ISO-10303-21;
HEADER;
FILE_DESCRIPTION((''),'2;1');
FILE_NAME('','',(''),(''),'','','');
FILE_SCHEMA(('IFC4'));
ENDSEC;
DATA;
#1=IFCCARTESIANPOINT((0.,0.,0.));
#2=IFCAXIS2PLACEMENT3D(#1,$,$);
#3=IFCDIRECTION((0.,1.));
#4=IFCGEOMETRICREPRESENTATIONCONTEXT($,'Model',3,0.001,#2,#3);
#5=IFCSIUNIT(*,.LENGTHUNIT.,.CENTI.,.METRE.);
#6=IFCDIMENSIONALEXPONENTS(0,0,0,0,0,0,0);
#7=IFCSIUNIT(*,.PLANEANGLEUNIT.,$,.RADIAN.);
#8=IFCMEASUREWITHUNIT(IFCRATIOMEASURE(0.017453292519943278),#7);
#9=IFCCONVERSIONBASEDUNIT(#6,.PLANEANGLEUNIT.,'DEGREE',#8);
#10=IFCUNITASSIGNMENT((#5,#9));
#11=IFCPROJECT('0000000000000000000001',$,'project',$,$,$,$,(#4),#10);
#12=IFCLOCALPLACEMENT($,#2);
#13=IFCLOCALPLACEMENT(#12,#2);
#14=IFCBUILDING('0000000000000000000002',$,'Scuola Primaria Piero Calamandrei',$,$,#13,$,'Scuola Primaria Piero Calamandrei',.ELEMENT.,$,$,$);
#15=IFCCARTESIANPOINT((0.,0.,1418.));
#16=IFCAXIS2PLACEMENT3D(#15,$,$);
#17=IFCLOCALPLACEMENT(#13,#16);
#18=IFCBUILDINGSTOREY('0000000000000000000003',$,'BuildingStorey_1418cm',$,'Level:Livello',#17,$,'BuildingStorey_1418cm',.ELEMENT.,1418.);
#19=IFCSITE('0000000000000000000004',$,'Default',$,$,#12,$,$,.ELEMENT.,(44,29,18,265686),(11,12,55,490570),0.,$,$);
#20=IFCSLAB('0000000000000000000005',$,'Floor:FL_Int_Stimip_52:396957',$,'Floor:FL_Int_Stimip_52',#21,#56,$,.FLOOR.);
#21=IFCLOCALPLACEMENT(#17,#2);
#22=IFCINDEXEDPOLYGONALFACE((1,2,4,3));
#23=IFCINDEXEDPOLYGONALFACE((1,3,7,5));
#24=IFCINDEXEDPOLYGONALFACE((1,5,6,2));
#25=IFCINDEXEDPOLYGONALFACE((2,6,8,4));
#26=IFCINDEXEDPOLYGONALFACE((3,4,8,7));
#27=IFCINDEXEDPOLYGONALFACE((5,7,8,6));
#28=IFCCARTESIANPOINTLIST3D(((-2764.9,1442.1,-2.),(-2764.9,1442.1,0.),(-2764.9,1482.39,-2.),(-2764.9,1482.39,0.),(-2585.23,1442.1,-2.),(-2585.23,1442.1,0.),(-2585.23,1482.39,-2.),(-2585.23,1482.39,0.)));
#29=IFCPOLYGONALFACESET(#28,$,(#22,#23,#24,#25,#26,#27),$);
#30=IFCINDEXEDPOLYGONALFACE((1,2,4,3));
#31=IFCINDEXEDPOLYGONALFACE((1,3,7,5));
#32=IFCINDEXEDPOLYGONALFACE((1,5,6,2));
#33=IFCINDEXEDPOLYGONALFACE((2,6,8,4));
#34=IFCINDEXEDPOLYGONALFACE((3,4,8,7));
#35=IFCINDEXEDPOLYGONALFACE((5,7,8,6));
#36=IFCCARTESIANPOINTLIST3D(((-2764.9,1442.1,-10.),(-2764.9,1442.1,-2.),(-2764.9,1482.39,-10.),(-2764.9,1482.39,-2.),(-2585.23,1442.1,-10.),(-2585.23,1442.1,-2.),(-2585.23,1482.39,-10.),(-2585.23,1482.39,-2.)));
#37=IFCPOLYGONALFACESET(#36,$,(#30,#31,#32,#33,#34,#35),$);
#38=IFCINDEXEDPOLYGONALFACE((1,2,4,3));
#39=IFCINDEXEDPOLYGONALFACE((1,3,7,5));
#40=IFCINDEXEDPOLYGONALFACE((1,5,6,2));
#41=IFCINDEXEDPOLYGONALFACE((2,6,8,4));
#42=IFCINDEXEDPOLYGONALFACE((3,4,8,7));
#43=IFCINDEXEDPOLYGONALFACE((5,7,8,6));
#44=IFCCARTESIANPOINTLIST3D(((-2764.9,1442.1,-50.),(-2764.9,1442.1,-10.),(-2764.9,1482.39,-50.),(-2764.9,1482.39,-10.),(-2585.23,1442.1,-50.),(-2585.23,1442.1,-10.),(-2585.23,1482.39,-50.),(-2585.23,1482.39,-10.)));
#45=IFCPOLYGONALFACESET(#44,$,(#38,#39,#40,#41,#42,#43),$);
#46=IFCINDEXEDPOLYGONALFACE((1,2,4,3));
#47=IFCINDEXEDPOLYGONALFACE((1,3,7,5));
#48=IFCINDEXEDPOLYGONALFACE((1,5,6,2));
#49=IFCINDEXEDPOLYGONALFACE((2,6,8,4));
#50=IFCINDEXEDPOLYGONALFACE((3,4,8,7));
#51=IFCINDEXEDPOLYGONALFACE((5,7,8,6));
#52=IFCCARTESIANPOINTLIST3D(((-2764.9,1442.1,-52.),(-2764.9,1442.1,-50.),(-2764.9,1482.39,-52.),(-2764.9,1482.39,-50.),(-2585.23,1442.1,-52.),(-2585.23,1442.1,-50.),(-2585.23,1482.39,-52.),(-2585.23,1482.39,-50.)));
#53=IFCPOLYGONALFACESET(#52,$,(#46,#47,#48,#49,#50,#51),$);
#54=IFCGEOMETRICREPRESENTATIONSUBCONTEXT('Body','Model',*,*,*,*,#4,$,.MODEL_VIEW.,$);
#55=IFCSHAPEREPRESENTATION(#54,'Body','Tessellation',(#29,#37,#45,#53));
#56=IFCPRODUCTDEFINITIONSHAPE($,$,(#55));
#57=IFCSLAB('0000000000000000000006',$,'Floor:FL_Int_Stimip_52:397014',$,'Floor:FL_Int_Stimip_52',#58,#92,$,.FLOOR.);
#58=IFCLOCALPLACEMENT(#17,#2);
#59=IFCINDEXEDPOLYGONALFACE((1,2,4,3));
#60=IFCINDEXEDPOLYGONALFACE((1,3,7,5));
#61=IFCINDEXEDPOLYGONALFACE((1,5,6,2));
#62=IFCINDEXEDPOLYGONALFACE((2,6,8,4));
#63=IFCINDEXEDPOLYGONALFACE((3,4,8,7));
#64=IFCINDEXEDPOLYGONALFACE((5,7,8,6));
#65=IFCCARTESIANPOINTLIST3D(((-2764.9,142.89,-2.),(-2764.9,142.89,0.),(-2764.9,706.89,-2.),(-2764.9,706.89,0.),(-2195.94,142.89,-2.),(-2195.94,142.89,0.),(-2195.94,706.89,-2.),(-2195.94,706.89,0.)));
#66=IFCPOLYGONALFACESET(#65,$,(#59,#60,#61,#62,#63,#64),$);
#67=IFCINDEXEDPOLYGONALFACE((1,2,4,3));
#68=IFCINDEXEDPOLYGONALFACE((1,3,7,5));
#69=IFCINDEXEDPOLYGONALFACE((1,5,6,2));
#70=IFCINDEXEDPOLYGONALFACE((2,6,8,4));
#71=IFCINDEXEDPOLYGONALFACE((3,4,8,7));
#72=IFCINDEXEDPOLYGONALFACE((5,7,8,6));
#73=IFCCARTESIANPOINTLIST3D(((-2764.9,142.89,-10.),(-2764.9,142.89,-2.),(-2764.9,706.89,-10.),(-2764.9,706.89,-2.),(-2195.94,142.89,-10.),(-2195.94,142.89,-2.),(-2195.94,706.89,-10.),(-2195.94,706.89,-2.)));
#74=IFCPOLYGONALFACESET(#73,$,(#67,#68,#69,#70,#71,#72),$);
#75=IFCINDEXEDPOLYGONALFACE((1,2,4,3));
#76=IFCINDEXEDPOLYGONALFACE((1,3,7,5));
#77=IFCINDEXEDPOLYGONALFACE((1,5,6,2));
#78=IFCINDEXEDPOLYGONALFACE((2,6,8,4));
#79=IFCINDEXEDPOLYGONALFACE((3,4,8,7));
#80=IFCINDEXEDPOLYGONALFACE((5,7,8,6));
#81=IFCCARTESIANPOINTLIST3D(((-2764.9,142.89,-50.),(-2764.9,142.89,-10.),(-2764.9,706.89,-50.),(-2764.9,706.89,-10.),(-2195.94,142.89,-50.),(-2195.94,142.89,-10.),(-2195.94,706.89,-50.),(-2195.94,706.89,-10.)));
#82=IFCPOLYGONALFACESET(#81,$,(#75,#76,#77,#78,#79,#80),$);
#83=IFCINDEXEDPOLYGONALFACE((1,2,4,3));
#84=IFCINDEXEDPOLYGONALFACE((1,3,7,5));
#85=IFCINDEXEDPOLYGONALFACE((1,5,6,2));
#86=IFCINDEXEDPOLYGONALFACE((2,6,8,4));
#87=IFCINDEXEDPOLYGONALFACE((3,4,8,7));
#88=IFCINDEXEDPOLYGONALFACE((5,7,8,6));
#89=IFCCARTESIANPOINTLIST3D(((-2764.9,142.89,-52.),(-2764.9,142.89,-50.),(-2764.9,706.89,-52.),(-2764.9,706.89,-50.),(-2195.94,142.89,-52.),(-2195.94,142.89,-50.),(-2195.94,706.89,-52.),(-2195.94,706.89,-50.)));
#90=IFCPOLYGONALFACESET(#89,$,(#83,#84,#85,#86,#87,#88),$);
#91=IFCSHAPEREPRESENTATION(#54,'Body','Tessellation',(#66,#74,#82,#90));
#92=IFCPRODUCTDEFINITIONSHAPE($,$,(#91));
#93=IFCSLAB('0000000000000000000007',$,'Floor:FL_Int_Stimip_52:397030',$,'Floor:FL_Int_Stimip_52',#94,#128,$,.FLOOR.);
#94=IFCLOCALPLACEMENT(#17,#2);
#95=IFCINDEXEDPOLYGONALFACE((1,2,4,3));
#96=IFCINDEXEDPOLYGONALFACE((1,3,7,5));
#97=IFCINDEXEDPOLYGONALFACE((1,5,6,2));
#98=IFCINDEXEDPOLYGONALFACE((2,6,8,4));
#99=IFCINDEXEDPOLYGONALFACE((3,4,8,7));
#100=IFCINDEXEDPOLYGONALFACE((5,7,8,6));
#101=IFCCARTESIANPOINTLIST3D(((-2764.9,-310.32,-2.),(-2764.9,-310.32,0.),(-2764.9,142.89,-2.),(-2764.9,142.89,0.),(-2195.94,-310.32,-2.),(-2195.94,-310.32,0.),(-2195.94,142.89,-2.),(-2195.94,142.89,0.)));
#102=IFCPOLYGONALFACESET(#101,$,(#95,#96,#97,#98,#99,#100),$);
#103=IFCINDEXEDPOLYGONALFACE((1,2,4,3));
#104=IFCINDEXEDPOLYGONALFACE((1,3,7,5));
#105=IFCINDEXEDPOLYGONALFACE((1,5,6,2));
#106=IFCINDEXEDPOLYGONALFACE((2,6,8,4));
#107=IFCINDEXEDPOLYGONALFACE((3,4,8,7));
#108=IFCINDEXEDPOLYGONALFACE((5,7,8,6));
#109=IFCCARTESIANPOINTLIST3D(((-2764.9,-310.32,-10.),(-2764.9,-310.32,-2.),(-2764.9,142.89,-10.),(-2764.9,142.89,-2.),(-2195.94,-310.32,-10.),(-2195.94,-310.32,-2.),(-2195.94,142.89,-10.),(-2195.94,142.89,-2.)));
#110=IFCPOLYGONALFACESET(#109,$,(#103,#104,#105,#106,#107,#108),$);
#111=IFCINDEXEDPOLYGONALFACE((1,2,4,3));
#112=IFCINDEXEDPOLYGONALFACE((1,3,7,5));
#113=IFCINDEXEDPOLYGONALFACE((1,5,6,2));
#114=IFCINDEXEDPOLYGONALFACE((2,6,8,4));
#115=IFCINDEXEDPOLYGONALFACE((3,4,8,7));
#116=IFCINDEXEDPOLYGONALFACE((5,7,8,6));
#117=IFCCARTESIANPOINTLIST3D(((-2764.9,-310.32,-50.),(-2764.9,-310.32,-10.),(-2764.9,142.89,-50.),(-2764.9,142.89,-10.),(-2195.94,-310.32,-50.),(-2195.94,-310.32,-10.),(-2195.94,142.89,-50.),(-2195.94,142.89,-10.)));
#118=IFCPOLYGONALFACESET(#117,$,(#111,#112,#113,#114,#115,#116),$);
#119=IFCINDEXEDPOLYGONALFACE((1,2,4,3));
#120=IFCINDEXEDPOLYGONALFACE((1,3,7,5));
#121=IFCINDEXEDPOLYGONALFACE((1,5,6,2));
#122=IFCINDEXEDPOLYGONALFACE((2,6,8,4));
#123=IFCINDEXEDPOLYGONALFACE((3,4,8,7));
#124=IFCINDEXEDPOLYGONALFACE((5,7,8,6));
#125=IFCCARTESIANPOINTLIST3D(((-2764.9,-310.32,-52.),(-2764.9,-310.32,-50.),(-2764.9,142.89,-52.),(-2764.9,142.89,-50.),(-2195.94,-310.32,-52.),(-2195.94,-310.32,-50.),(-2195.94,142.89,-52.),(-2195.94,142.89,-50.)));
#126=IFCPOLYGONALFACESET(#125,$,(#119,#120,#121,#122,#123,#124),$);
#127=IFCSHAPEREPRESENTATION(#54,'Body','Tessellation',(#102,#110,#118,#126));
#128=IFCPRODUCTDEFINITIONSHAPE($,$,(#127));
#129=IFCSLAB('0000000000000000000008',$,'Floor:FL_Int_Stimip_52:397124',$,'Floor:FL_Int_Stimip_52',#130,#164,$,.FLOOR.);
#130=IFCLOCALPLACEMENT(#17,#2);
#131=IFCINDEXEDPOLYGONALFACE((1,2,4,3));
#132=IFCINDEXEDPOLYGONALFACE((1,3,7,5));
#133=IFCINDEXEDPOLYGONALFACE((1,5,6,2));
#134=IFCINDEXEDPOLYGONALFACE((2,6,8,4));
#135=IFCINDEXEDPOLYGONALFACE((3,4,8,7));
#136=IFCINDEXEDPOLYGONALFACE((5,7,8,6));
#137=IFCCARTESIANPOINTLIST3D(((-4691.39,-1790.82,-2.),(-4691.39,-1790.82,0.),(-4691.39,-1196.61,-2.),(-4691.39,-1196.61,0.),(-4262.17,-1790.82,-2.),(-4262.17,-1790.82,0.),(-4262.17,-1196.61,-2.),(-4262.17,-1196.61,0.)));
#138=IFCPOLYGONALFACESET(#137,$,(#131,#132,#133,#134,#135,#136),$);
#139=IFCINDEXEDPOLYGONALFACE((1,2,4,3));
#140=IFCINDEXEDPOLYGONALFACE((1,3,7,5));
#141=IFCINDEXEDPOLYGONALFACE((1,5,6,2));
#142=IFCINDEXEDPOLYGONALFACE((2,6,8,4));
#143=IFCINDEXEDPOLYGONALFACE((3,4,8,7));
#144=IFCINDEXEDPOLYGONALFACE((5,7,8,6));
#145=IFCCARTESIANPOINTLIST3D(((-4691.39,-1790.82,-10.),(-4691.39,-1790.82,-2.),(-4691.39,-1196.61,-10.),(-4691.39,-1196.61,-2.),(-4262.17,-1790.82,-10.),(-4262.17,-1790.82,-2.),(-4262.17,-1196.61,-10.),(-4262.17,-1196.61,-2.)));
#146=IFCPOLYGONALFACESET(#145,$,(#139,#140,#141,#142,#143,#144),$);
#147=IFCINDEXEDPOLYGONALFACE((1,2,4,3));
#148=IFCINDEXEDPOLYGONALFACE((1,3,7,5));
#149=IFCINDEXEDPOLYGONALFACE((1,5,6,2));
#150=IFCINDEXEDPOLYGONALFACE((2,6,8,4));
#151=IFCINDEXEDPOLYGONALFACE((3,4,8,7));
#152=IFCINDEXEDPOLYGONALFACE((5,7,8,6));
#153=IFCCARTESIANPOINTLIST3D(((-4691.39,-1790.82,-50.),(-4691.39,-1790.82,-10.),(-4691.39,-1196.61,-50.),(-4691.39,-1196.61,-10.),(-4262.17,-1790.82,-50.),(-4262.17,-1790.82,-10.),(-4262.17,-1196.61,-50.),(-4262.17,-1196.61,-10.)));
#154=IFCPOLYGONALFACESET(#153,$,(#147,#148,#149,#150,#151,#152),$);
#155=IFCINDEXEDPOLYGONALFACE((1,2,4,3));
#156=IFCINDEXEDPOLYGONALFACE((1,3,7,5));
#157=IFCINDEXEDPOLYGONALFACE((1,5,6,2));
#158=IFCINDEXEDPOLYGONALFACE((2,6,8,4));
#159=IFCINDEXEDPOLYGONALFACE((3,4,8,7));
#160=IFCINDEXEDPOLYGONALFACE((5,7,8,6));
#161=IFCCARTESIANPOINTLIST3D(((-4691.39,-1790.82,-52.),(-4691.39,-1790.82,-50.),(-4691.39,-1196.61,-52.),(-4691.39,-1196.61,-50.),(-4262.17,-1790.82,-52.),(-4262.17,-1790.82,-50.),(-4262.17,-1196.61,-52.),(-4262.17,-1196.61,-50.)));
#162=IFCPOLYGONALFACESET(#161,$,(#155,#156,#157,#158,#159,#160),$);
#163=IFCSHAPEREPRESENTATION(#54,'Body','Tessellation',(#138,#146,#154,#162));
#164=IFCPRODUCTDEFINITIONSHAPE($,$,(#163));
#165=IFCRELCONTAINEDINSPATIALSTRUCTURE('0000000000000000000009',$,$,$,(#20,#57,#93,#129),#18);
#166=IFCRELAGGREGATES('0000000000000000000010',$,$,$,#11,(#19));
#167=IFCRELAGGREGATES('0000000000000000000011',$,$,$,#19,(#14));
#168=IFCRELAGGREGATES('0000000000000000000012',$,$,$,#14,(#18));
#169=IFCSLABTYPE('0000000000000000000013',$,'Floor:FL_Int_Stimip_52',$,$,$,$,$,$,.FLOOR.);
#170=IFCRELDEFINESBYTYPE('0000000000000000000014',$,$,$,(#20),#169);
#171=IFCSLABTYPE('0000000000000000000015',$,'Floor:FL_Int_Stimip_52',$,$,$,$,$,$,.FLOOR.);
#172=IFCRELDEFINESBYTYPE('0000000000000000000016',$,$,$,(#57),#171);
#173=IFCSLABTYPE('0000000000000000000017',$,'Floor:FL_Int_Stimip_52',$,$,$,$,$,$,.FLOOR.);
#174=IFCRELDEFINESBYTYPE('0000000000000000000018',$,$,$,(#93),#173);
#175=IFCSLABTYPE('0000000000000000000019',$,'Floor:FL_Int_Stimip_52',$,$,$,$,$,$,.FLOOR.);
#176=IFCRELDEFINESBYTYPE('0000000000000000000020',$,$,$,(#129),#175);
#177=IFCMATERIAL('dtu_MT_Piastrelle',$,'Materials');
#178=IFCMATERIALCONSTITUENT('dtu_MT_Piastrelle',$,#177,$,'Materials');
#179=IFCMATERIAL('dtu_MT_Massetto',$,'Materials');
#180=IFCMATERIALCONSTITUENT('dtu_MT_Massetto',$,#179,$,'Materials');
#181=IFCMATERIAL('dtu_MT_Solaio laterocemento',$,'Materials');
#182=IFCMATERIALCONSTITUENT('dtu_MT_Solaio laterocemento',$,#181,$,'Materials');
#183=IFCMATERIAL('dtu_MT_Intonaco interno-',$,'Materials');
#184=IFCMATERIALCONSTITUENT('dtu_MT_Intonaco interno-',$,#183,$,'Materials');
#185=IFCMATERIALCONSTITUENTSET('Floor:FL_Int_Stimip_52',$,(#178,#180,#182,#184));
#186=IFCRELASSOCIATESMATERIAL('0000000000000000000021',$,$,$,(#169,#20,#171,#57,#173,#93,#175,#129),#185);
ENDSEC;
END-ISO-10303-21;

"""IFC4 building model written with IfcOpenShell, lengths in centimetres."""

from ifc_helpers import new_model, entity, si_unit, converted_unit, direction, frame, origin, place, context, subcontext, project, spatial, indexed_curve, outline, extrude, material, constituent, constituent_set, type_object, element, save


model = new_model("IFC4")

# Units and contexts
model_context = context("Model", 3, precision=0.001, world=origin(), true_north=direction((0.0, 1.0)))
body_context = subcontext(model_context, "Body", "Model", "MODEL_VIEW")
ifc_project = project(units=[si_unit("LENGTHUNIT", "METRE", prefix="CENTI"), converted_unit("PLANEANGLEUNIT", "DEGREE", entity("IfcRatioMeasure", 0.017453292519943278), si_unit("PLANEANGLEUNIT", "RADIAN"), dimensions=[0, 0, 0, 0, 0, 0, 0])], contexts=[model_context])

# Site, building, storey
site_placement = place(None, origin())
site = spatial("IfcSite", under=ifc_project, at=site_placement, Name="Default", CompositionType="ELEMENT", RefLatitude=(44, 29, 18, 265686), RefLongitude=(11, 12, 55, 490570), RefElevation=0.0)
building_placement = place(site_placement, origin())
building = spatial("IfcBuilding", under=site, at=building_placement, Name="Scuola Primaria Piero Calamandrei", LongName="Scuola Primaria Piero Calamandrei", CompositionType="ELEMENT")
storey_placement = place(building_placement, frame((0.0, 0.0, 1418.0)))
storey = spatial("IfcBuildingStorey", under=building, at=storey_placement, Name="BuildingStorey_1418cm", ObjectType="Level:Livello", LongName="BuildingStorey_1418cm", CompositionType="ELEMENT", Elevation=1418.0)

# Slabs
ifc_material_1 = material(Name="dtu_MT_Piastrelle", Category="Materials")
ifc_constituent_1 = constituent(ifc_material_1, Name="dtu_MT_Piastrelle", Category="Materials")
ifc_material_2 = material(Name="dtu_MT_Massetto", Category="Materials")
ifc_constituent_2 = constituent(ifc_material_2, Name="dtu_MT_Massetto", Category="Materials")
ifc_material_3 = material(Name="dtu_MT_Solaio laterocemento", Category="Materials")
ifc_constituent_3 = constituent(ifc_material_3, Name="dtu_MT_Solaio laterocemento", Category="Materials")
ifc_material_4 = material(Name="dtu_MT_Intonaco interno-", Category="Materials")
ifc_constituent_4 = constituent(ifc_material_4, Name="dtu_MT_Intonaco interno-", Category="Materials")
ifc_constituent_set = constituent_set(constituents=[ifc_constituent_1, ifc_constituent_2, ifc_constituent_3, ifc_constituent_4], Name="Floor:FL_Int_Stimip_52")
slab_type_1 = type_object("IfcSlabType", Name="Floor:FL_Int_Stimip_52", PredefinedType="FLOOR", material=ifc_constituent_set)
slab_1_placement = place(storey_placement, origin())
element("IfcSlab", 1, at=slab_1_placement, inside=storey, type_object=slab_type_1, material=ifc_constituent_set, Name="Floor:FL_Int_Stimip_52:396957", ObjectType="Floor:FL_Int_Stimip_52", PredefinedType="FLOOR", context=body_context, shape_type="SweptSolid", body=[
    extrude(outline(indexed_curve([(-89.84, -20.14), (89.84, -20.14), (89.84, 20.14), (-89.84, 20.14), (-89.84, -20.14)], self_intersect=False)), frame((-2675.07, 1462.25, -2.0), z_axis=(0.0, 0.0, 1.0), x_axis=(-1.0, 0.0, 0.0)), (0.0, 0.0, 1.0), 2.0),
    extrude(outline(indexed_curve([(-89.84, -20.14), (89.84, -20.14), (89.84, 20.14), (-89.84, 20.14), (-89.84, -20.14)], self_intersect=False)), frame((-2675.07, 1462.25, -10.0), z_axis=(0.0, 0.0, 1.0), x_axis=(-1.0, 0.0, 0.0)), (0.0, 0.0, 1.0), 8.0),
    extrude(outline(indexed_curve([(-89.84, -20.14), (89.84, -20.14), (89.84, 20.14), (-89.84, 20.14), (-89.84, -20.14)], self_intersect=False)), frame((-2675.07, 1462.25, -50.0), z_axis=(0.0, 0.0, 1.0), x_axis=(-1.0, 0.0, 0.0)), (0.0, 0.0, 1.0), 40.0),
    extrude(outline(indexed_curve([(-89.84, -20.14), (89.84, -20.14), (89.84, 20.14), (-89.84, 20.14), (-89.84, -20.14)], self_intersect=False)), frame((-2675.07, 1462.25, -52.0), z_axis=(0.0, 0.0, 1.0), x_axis=(-1.0, 0.0, 0.0)), (0.0, 0.0, 1.0), 2.0),
])
slab_type_2 = type_object("IfcSlabType", Name="Floor:FL_Int_Stimip_52", PredefinedType="FLOOR", material=ifc_constituent_set)
slab_2_placement = place(storey_placement, origin())
element("IfcSlab", 2, at=slab_2_placement, inside=storey, type_object=slab_type_2, material=ifc_constituent_set, Name="Floor:FL_Int_Stimip_52:397014", ObjectType="Floor:FL_Int_Stimip_52", PredefinedType="FLOOR", context=body_context, shape_type="SweptSolid", body=[
    extrude(outline(indexed_curve([(-284.48, -282.0), (284.48, -282.0), (284.48, 282.0), (-284.48, 282.0), (-284.48, -282.0)], self_intersect=False)), frame((-2480.42, 424.89, -2.0)), (0.0, 0.0, 1.0), 2.0),
    extrude(outline(indexed_curve([(-284.48, -282.0), (284.48, -282.0), (284.48, 282.0), (-284.48, 282.0), (-284.48, -282.0)], self_intersect=False)), frame((-2480.42, 424.89, -10.0)), (0.0, 0.0, 1.0), 8.0),
    extrude(outline(indexed_curve([(-284.48, -282.0), (284.48, -282.0), (284.48, 282.0), (-284.48, 282.0), (-284.48, -282.0)], self_intersect=False)), frame((-2480.42, 424.89, -50.0)), (0.0, 0.0, 1.0), 40.0),
    extrude(outline(indexed_curve([(-284.48, -282.0), (284.48, -282.0), (284.48, 282.0), (-284.48, 282.0), (-284.48, -282.0)], self_intersect=False)), frame((-2480.42, 424.89, -52.0)), (0.0, 0.0, 1.0), 2.0),
])
slab_type_3 = type_object("IfcSlabType", Name="Floor:FL_Int_Stimip_52", PredefinedType="FLOOR", material=ifc_constituent_set)
slab_3_placement = place(storey_placement, origin())
element("IfcSlab", 3, at=slab_3_placement, inside=storey, type_object=slab_type_3, material=ifc_constituent_set, Name="Floor:FL_Int_Stimip_52:397030", ObjectType="Floor:FL_Int_Stimip_52", PredefinedType="FLOOR", context=body_context, shape_type="SweptSolid", body=[
    extrude(outline(indexed_curve([(-284.48, -226.61), (284.48, -226.61), (284.48, 226.61), (-284.48, 226.61), (-284.48, -226.61)], self_intersect=False)), frame((-2480.42, -83.72, -2.0)), (0.0, 0.0, 1.0), 2.0),
    extrude(outline(indexed_curve([(-284.48, -226.61), (284.48, -226.61), (284.48, 226.61), (-284.48, 226.61), (-284.48, -226.61)], self_intersect=False)), frame((-2480.42, -83.72, -10.0)), (0.0, 0.0, 1.0), 8.0),
    extrude(outline(indexed_curve([(-284.48, -226.61), (284.48, -226.61), (284.48, 226.61), (-284.48, 226.61), (-284.48, -226.61)], self_intersect=False)), frame((-2480.42, -83.72, -50.0)), (0.0, 0.0, 1.0), 40.0),
    extrude(outline(indexed_curve([(-284.48, -226.61), (284.48, -226.61), (284.48, 226.61), (-284.48, 226.61), (-284.48, -226.61)], self_intersect=False)), frame((-2480.42, -83.72, -52.0)), (0.0, 0.0, 1.0), 2.0),
])
slab_type_4 = type_object("IfcSlabType", Name="Floor:FL_Int_Stimip_52", PredefinedType="FLOOR", material=ifc_constituent_set)
slab_4_placement = place(storey_placement, origin())
element("IfcSlab", 4, at=slab_4_placement, inside=storey, type_object=slab_type_4, material=ifc_constituent_set, Name="Floor:FL_Int_Stimip_52:397124", ObjectType="Floor:FL_Int_Stimip_52", PredefinedType="FLOOR", context=body_context, shape_type="SweptSolid", body=[
    extrude(outline(indexed_curve([(-297.11, -214.61), (297.11, -214.61), (297.11, 214.61), (-297.11, 214.61), (-297.11, -214.61)], self_intersect=False)), frame((-4476.78, -1493.71, -2.0), z_axis=(0.0, 0.0, 1.0), x_axis=(0.0, 1.0, 0.0)), (0.0, 0.0, 1.0), 2.0),
    extrude(outline(indexed_curve([(-297.11, -214.61), (297.11, -214.61), (297.11, 214.61), (-297.11, 214.61), (-297.11, -214.61)], self_intersect=False)), frame((-4476.78, -1493.71, -10.0), z_axis=(0.0, 0.0, 1.0), x_axis=(0.0, 1.0, 0.0)), (0.0, 0.0, 1.0), 8.0),
    extrude(outline(indexed_curve([(-297.11, -214.61), (297.11, -214.61), (297.11, 214.61), (-297.11, 214.61), (-297.11, -214.61)], self_intersect=False)), frame((-4476.78, -1493.71, -50.0), z_axis=(0.0, 0.0, 1.0), x_axis=(0.0, 1.0, 0.0)), (0.0, 0.0, 1.0), 40.0),
    extrude(outline(indexed_curve([(-297.11, -214.61), (297.11, -214.61), (297.11, 214.61), (-297.11, 214.61), (-297.11, -214.61)], self_intersect=False)), frame((-4476.78, -1493.71, -52.0), z_axis=(0.0, 0.0, 1.0), x_axis=(0.0, 1.0, 0.0)), (0.0, 0.0, 1.0), 2.0),
])

save(model, "model.ifc")
